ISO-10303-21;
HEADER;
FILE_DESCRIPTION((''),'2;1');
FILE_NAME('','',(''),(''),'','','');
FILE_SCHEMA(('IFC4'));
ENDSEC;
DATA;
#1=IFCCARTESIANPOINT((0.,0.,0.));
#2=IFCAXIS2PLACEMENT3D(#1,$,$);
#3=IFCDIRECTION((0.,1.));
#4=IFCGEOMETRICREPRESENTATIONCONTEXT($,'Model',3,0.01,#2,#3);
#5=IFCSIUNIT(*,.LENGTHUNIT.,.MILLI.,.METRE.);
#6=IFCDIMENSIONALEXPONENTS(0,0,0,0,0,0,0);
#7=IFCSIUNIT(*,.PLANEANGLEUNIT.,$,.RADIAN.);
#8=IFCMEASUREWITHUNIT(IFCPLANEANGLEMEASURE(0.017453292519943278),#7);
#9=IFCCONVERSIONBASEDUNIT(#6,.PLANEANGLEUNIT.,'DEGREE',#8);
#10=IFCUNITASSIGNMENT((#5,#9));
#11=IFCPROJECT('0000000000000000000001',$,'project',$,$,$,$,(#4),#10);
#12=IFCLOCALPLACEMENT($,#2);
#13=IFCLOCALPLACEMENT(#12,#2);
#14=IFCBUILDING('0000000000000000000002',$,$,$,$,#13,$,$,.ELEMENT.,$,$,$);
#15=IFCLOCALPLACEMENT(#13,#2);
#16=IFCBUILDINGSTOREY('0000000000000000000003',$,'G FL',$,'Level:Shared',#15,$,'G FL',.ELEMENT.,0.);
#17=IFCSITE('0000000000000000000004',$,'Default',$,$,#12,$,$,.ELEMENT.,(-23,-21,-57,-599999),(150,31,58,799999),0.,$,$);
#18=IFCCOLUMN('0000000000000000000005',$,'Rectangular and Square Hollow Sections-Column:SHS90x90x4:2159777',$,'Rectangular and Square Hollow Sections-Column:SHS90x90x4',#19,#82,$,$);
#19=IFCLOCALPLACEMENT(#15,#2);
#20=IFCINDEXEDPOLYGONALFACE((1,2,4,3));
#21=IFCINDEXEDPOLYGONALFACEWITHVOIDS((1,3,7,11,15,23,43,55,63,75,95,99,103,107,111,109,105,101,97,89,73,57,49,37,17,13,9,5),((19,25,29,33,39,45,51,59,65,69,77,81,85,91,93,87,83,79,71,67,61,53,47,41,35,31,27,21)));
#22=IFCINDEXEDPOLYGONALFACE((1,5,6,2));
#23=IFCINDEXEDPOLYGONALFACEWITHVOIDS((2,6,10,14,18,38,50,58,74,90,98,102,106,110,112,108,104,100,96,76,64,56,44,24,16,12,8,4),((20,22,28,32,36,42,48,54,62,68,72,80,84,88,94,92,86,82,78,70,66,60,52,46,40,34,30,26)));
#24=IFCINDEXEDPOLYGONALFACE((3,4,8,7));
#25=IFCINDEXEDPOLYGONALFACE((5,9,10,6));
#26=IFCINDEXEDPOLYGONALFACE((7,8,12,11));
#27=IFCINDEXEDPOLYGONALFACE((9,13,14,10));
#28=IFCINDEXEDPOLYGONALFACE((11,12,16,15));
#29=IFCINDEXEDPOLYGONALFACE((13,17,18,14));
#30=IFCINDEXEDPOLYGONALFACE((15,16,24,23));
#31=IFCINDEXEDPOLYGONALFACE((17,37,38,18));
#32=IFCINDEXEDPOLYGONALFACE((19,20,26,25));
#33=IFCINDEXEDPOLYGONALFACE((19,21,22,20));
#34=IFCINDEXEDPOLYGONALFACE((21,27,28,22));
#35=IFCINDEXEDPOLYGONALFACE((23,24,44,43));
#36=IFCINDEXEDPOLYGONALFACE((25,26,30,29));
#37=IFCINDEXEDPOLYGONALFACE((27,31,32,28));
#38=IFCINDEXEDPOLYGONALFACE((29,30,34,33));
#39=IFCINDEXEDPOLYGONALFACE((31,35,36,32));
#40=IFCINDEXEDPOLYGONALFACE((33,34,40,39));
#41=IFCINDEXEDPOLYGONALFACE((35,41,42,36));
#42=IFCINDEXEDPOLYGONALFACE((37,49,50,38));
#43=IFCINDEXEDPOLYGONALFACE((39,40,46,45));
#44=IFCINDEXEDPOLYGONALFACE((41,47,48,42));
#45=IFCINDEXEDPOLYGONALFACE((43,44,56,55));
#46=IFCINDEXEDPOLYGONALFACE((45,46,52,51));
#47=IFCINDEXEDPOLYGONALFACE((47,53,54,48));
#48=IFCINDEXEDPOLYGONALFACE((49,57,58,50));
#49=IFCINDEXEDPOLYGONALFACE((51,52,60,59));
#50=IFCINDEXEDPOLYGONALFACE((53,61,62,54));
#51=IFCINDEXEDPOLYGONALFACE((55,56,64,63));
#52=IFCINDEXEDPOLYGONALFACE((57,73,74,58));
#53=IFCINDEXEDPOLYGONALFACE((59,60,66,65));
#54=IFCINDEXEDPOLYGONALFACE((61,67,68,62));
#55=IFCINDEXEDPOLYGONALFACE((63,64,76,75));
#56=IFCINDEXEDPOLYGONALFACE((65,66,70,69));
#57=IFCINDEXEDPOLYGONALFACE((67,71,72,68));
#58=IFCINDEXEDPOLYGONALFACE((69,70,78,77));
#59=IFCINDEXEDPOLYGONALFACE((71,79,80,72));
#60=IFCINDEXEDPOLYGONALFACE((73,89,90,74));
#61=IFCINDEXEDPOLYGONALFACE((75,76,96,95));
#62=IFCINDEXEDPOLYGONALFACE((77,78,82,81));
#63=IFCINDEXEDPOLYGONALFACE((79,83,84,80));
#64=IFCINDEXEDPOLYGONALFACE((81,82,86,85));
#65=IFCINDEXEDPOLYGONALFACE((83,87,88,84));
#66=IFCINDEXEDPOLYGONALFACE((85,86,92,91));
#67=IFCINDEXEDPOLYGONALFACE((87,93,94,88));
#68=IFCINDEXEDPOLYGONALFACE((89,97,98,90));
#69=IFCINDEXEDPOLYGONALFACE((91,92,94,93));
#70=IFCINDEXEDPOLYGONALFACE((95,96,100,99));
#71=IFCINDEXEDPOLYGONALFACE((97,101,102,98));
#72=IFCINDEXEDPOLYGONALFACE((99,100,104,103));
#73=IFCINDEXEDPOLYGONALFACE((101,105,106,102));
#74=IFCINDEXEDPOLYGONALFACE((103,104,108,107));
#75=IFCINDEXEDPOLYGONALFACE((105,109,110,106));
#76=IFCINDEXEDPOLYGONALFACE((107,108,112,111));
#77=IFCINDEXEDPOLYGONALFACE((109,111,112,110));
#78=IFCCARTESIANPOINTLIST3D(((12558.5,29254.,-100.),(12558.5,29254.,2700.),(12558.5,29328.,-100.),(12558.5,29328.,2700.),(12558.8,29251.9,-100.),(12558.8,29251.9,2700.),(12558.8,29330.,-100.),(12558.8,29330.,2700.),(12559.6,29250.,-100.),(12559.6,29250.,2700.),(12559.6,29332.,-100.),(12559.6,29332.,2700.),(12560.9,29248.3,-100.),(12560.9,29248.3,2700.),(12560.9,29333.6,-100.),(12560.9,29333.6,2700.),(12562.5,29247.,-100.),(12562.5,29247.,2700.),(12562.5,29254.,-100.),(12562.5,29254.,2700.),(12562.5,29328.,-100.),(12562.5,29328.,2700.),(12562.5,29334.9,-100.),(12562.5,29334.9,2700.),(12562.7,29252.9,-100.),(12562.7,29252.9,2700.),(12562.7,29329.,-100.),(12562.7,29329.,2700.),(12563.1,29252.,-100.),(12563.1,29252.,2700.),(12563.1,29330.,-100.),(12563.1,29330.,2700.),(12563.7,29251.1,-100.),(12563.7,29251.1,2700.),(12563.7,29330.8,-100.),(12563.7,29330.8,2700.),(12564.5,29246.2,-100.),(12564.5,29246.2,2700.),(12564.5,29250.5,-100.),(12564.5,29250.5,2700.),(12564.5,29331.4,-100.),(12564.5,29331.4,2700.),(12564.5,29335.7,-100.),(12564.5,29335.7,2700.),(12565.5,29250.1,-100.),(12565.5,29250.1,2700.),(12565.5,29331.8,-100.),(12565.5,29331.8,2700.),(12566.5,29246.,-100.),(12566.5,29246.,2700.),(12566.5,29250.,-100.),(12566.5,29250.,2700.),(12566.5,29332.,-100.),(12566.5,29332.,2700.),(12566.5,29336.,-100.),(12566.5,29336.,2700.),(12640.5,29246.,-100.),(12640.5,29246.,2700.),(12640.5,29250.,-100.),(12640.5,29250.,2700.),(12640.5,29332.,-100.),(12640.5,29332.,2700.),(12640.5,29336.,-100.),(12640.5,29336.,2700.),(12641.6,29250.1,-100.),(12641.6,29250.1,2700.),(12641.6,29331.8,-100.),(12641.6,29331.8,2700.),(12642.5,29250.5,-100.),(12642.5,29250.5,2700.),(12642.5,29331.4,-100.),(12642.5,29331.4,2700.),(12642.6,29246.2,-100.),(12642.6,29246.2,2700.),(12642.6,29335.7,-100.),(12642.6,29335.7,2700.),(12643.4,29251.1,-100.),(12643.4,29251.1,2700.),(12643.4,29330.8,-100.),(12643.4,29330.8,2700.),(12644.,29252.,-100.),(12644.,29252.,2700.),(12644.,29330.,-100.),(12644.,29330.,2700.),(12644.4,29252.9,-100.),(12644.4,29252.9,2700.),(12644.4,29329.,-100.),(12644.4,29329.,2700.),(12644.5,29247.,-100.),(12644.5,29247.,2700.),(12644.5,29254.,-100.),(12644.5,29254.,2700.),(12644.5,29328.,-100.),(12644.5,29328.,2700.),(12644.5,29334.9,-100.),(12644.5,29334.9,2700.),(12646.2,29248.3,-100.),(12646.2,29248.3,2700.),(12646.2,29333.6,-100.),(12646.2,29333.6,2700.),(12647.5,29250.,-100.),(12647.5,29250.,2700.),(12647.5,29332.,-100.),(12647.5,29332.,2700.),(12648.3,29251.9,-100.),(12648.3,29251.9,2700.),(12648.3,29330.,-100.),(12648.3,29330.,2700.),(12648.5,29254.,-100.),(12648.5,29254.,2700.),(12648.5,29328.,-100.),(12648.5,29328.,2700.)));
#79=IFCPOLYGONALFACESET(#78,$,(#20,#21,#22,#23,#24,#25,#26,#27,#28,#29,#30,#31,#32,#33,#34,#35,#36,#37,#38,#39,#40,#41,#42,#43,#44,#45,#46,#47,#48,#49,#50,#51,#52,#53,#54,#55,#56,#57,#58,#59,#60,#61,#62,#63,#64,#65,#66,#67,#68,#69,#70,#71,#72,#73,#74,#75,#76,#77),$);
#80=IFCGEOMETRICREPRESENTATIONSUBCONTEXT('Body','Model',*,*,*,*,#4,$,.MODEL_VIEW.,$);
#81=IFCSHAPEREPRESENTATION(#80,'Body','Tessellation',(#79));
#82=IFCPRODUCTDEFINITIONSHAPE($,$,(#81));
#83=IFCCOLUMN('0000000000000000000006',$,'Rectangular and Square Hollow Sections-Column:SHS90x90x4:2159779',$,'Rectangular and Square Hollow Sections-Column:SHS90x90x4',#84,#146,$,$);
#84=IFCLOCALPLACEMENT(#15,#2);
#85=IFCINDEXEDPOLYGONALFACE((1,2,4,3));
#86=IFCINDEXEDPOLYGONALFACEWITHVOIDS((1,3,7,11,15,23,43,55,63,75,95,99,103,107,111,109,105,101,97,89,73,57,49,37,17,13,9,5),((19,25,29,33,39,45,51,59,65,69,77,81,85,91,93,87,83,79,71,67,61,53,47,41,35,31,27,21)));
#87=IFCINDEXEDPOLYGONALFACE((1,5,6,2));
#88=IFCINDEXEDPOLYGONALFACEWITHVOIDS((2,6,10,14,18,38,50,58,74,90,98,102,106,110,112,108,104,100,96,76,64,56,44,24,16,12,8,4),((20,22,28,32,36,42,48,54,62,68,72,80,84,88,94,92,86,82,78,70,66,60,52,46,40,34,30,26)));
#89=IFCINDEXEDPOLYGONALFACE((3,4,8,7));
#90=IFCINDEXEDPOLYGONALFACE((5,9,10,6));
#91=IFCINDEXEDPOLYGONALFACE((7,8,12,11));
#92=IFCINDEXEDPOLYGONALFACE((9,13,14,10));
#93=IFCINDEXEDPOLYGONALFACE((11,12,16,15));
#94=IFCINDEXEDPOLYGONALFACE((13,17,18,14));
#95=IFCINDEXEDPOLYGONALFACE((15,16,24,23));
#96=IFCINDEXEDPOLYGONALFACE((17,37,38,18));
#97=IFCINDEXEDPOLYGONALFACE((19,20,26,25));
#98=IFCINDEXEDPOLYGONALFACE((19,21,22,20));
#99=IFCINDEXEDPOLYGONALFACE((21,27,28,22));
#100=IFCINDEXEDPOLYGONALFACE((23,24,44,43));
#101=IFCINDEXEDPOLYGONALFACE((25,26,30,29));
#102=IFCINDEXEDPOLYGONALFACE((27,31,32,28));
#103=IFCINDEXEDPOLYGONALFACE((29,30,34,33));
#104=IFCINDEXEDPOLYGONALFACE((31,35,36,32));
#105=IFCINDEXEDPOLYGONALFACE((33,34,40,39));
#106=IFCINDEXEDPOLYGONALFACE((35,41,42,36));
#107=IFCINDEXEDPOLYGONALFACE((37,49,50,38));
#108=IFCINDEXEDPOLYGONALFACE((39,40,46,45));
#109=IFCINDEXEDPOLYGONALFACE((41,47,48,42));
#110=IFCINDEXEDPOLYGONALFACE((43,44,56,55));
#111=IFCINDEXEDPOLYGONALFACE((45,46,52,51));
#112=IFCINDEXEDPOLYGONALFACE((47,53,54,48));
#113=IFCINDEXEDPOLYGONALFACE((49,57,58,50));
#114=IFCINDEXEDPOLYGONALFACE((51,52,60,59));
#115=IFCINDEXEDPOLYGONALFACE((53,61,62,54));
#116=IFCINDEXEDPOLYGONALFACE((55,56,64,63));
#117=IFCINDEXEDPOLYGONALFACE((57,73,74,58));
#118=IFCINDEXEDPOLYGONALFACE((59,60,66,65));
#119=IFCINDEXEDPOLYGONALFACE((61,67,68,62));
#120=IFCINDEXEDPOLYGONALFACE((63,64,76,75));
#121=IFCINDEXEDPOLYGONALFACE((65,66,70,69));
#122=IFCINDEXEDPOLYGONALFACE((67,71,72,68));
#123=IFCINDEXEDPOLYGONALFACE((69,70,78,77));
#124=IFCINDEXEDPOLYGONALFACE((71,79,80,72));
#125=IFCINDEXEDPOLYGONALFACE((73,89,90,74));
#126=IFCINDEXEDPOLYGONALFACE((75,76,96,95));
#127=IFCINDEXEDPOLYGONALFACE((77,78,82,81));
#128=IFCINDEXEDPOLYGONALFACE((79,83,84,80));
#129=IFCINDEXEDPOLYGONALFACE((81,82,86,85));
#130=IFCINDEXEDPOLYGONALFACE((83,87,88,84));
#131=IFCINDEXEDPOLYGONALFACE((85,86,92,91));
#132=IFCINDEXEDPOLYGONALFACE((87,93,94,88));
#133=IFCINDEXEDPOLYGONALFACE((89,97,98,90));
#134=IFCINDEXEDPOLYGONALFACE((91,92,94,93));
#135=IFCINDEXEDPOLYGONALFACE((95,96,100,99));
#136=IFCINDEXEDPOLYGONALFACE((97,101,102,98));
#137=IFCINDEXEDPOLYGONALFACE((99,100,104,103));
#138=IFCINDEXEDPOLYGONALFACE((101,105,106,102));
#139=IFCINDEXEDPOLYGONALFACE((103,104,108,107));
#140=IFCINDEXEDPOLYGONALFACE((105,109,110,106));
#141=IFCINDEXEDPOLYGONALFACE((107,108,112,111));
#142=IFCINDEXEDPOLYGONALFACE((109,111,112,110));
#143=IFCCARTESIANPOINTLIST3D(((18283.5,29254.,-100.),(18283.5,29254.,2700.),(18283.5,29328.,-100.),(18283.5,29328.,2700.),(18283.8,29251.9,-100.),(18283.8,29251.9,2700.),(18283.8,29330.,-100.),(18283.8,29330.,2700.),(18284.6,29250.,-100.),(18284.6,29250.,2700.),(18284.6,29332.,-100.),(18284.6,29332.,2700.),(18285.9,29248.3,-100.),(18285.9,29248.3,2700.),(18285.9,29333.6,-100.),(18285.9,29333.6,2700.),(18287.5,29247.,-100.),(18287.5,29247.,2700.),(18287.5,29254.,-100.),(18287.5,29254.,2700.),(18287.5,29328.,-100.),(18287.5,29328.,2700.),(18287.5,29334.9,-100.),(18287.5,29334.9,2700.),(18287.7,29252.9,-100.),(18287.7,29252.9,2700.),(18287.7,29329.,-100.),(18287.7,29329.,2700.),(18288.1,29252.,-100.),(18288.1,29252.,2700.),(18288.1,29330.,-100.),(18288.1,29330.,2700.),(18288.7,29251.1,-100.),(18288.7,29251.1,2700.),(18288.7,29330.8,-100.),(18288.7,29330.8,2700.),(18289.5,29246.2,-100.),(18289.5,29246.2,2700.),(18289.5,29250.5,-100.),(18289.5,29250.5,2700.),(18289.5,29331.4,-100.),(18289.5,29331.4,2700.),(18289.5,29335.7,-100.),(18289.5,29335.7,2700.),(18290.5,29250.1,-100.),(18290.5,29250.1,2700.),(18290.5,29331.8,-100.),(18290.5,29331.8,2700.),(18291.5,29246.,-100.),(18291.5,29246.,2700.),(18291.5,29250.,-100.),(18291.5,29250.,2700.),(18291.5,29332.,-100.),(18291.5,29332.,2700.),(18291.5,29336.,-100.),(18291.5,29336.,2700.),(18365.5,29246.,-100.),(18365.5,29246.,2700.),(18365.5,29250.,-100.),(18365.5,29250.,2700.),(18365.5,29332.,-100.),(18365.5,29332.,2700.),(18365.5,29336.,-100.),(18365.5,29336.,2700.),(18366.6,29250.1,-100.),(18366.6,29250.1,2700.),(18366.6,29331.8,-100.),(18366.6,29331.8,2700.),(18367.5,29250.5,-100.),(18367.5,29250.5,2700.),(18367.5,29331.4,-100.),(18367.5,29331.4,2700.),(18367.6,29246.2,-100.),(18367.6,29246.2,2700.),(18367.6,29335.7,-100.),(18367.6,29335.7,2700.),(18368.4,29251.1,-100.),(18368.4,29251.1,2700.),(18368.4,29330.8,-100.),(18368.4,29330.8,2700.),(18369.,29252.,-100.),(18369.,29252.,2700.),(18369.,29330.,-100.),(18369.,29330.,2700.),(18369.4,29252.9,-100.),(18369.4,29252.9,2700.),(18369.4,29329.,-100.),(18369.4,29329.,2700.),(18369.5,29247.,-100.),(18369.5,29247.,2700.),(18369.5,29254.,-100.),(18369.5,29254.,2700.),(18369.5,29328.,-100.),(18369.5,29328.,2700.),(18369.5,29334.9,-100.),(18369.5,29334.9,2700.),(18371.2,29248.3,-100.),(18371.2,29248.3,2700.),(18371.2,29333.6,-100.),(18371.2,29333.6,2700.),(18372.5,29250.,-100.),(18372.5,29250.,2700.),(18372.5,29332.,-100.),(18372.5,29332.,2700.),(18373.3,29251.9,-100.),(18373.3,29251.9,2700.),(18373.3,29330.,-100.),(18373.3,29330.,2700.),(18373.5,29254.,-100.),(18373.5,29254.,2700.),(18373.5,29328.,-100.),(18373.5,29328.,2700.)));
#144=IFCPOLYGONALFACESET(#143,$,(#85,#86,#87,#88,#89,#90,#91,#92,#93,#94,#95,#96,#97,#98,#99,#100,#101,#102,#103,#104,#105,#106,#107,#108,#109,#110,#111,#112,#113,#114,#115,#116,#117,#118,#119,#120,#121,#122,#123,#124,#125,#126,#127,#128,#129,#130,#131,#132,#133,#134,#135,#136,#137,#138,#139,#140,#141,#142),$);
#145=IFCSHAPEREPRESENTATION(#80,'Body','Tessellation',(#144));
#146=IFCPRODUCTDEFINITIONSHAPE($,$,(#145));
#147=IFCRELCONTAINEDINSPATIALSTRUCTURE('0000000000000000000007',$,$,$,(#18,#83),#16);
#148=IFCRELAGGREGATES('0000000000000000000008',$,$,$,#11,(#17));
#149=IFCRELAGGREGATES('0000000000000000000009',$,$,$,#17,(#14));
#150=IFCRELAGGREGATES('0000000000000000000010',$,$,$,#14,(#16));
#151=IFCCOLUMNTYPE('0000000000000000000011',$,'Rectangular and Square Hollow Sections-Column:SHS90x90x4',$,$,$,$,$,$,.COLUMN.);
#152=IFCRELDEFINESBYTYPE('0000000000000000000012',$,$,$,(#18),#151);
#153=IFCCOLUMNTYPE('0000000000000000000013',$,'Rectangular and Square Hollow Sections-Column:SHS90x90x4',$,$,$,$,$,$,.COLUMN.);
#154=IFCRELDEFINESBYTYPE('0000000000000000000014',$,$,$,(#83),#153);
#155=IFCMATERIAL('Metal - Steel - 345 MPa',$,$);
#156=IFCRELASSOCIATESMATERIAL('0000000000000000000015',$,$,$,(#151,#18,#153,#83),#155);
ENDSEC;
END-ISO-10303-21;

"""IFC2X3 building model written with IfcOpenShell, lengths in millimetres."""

from ifc_helpers import new_model, entity, si_unit, converted_unit, direction, frame, frame_2d, origin, place, context, subcontext, project, spatial, polyline, circle_curve, parameter, trimmed, segment, composite_curve, outline, extrude, source, transform, mapped, material, type_object, type_shapes, element, save


model = new_model("IFC2X3")

# Units and contexts
model_context = context("Model", 3, precision=0.01, world=origin(), true_north=direction((0.0, 1.0)))
body_context = subcontext(model_context, "Body", "Model", "MODEL_VIEW")
ifc_project = project(units=[si_unit("LENGTHUNIT", "METRE", prefix="MILLI"), converted_unit("PLANEANGLEUNIT", "DEGREE", entity("IfcPlaneAngleMeasure", 0.017453292519943278), si_unit("PLANEANGLEUNIT", "RADIAN"), dimensions=[0, 0, 0, 0, 0, 0, 0])], contexts=[model_context])

# Site, building, storey
site_placement = place(None, origin())
site = spatial("IfcSite", under=ifc_project, at=site_placement, Name="Default", CompositionType="ELEMENT", RefLatitude=(-23, -21, -57, -599999), RefLongitude=(150, 31, 58, 799999), RefElevation=0.0)
building_placement = place(site_placement, origin())
building = spatial("IfcBuilding", under=site, at=building_placement, CompositionType="ELEMENT")
storey_placement = place(building_placement, origin())
storey = spatial("IfcBuildingStorey", under=building, at=storey_placement, Name="G FL", ObjectType="Level:Shared", LongName="G FL", CompositionType="ELEMENT", Elevation=0.0)

# Columns
ifc_material_1 = material(Name="Metal - Steel - 345 MPa")
column_type_1 = type_object("IfcColumnType", Name="Rectangular and Square Hollow Sections-Column:SHS90x90x4", PredefinedType="COLUMN", material=ifc_material_1)
shared_shape_1 = source(origin(), body_context, "Body", "SweptSolid", [
    extrude(outline(composite_curve([segment(trimmed(circle_curve(frame_2d((37.0, -37.0), x_axis=(1.0, 0.0)), 8.0), [parameter(270.0)], [parameter(0.0)], True, "PARAMETER"), True, "CONTINUOUS"), segment(polyline([(45.0, -37.0), (45.0, 37.0)]), True, "CONTINUOUS"), segment(trimmed(circle_curve(frame_2d((37.0, 37.0), x_axis=(1.0, 0.0)), 8.0), [parameter(0.0)], [parameter(90.0)], True, "PARAMETER"), True, "CONTINUOUS"), segment(polyline([(37.0, 45.0), (-37.0, 45.0)]), True, "CONTINUOUS"), segment(trimmed(circle_curve(frame_2d((-37.0, 37.0), x_axis=(1.0, 0.0)), 8.0), [parameter(90.0)], [parameter(180.0)], True, "PARAMETER"), True, "CONTINUOUS"), segment(polyline([(-45.0, 37.0), (-45.0, -37.0)]), True, "CONTINUOUS"), segment(trimmed(circle_curve(frame_2d((-37.0, -37.0), x_axis=(1.0, 0.0)), 8.0), [parameter(180.0)], [parameter(270.0)], True, "PARAMETER"), True, "CONTINUOUS"), segment(polyline([(-37.0, -45.0), (37.0, -45.0)]), True, "CONTINUOUS")], self_intersect=False), holes=[composite_curve([segment(polyline([(37.0, -41.0), (-37.0, -41.0)]), True, "CONTINUOUS"), segment(trimmed(circle_curve(frame_2d((-37.0, -37.0), x_axis=(1.0, 0.0)), 4.0), [parameter(180.0)], [parameter(270.0)], True, "PARAMETER"), False, "CONTINUOUS"), segment(polyline([(-41.0, -37.0), (-41.0, 37.0)]), True, "CONTINUOUS"), segment(trimmed(circle_curve(frame_2d((-37.0, 37.0), x_axis=(1.0, 0.0)), 4.0), [parameter(90.0)], [parameter(180.0)], True, "PARAMETER"), False, "CONTINUOUS"), segment(polyline([(-37.0, 41.0), (37.0, 41.0)]), True, "CONTINUOUS"), segment(trimmed(circle_curve(frame_2d((37.0, 37.0), x_axis=(1.0, 0.0)), 4.0), [parameter(0.0)], [parameter(90.0)], True, "PARAMETER"), False, "CONTINUOUS"), segment(polyline([(41.0, 37.0), (41.0, -37.0)]), True, "CONTINUOUS"), segment(trimmed(circle_curve(frame_2d((37.0, -37.0), x_axis=(1.0, 0.0)), 4.0), [parameter(270.0)], [parameter(0.0)], True, "PARAMETER"), False, "CONTINUOUS")], self_intersect=False)]), frame((12603.5, 29291.0, -100.0)), (0.0, 0.0, 1.0), 2800.0),
])
type_shapes(column_type_1, [shared_shape_1])
column_1_placement = place(storey_placement, origin())
element("IfcColumn", 1, at=column_1_placement, inside=storey, type_object=column_type_1, material=ifc_material_1, Name="Rectangular and Square Hollow Sections-Column:SHS90x90x4:2159777", ObjectType="Rectangular and Square Hollow Sections-Column:SHS90x90x4", context=body_context, shape_type="MappedRepresentation", body=[
    mapped(shared_shape_1, transform((0.0, 0.0, 0.0), scale=1.0)),
])
column_type_2 = type_object("IfcColumnType", Name="Rectangular and Square Hollow Sections-Column:SHS90x90x4", PredefinedType="COLUMN", material=ifc_material_1)
shared_shape_2 = source(origin(), body_context, "Body", "SweptSolid", [
    extrude(outline(composite_curve([segment(trimmed(circle_curve(frame_2d((37.0, -37.0), x_axis=(1.0, 0.0)), 8.0), [parameter(270.0)], [parameter(0.0)], True, "PARAMETER"), True, "CONTINUOUS"), segment(polyline([(45.0, -37.0), (45.0, 37.0)]), True, "CONTINUOUS"), segment(trimmed(circle_curve(frame_2d((37.0, 37.0), x_axis=(1.0, 0.0)), 8.0), [parameter(0.0)], [parameter(90.0)], True, "PARAMETER"), True, "CONTINUOUS"), segment(polyline([(37.0, 45.0), (-37.0, 45.0)]), True, "CONTINUOUS"), segment(trimmed(circle_curve(frame_2d((-37.0, 37.0), x_axis=(1.0, 0.0)), 8.0), [parameter(90.0)], [parameter(180.0)], True, "PARAMETER"), True, "CONTINUOUS"), segment(polyline([(-45.0, 37.0), (-45.0, -37.0)]), True, "CONTINUOUS"), segment(trimmed(circle_curve(frame_2d((-37.0, -37.0), x_axis=(1.0, 0.0)), 8.0), [parameter(180.0)], [parameter(270.0)], True, "PARAMETER"), True, "CONTINUOUS"), segment(polyline([(-37.0, -45.0), (37.0, -45.0)]), True, "CONTINUOUS")], self_intersect=False), holes=[composite_curve([segment(polyline([(37.0, -41.0), (-37.0, -41.0)]), True, "CONTINUOUS"), segment(trimmed(circle_curve(frame_2d((-37.0, -37.0), x_axis=(1.0, 0.0)), 4.0), [parameter(180.0)], [parameter(270.0)], True, "PARAMETER"), False, "CONTINUOUS"), segment(polyline([(-41.0, -37.0), (-41.0, 37.0)]), True, "CONTINUOUS"), segment(trimmed(circle_curve(frame_2d((-37.0, 37.0), x_axis=(1.0, 0.0)), 4.0), [parameter(90.0)], [parameter(180.0)], True, "PARAMETER"), False, "CONTINUOUS"), segment(polyline([(-37.0, 41.0), (37.0, 41.0)]), True, "CONTINUOUS"), segment(trimmed(circle_curve(frame_2d((37.0, 37.0), x_axis=(1.0, 0.0)), 4.0), [parameter(0.0)], [parameter(90.0)], True, "PARAMETER"), False, "CONTINUOUS"), segment(polyline([(41.0, 37.0), (41.0, -37.0)]), True, "CONTINUOUS"), segment(trimmed(circle_curve(frame_2d((37.0, -37.0), x_axis=(1.0, 0.0)), 4.0), [parameter(270.0)], [parameter(0.0)], True, "PARAMETER"), False, "CONTINUOUS")], self_intersect=False)]), frame((18328.5, 29291.0, -100.0)), (0.0, 0.0, 1.0), 2800.0),
])
type_shapes(column_type_2, [shared_shape_2])
column_2_placement = place(storey_placement, origin())
element("IfcColumn", 2, at=column_2_placement, inside=storey, type_object=column_type_2, material=ifc_material_1, Name="Rectangular and Square Hollow Sections-Column:SHS90x90x4:2159779", ObjectType="Rectangular and Square Hollow Sections-Column:SHS90x90x4", context=body_context, shape_type="MappedRepresentation", body=[
    mapped(shared_shape_2, transform((0.0, 0.0, 0.0), scale=1.0)),
])

save(model, "model.ifc")
